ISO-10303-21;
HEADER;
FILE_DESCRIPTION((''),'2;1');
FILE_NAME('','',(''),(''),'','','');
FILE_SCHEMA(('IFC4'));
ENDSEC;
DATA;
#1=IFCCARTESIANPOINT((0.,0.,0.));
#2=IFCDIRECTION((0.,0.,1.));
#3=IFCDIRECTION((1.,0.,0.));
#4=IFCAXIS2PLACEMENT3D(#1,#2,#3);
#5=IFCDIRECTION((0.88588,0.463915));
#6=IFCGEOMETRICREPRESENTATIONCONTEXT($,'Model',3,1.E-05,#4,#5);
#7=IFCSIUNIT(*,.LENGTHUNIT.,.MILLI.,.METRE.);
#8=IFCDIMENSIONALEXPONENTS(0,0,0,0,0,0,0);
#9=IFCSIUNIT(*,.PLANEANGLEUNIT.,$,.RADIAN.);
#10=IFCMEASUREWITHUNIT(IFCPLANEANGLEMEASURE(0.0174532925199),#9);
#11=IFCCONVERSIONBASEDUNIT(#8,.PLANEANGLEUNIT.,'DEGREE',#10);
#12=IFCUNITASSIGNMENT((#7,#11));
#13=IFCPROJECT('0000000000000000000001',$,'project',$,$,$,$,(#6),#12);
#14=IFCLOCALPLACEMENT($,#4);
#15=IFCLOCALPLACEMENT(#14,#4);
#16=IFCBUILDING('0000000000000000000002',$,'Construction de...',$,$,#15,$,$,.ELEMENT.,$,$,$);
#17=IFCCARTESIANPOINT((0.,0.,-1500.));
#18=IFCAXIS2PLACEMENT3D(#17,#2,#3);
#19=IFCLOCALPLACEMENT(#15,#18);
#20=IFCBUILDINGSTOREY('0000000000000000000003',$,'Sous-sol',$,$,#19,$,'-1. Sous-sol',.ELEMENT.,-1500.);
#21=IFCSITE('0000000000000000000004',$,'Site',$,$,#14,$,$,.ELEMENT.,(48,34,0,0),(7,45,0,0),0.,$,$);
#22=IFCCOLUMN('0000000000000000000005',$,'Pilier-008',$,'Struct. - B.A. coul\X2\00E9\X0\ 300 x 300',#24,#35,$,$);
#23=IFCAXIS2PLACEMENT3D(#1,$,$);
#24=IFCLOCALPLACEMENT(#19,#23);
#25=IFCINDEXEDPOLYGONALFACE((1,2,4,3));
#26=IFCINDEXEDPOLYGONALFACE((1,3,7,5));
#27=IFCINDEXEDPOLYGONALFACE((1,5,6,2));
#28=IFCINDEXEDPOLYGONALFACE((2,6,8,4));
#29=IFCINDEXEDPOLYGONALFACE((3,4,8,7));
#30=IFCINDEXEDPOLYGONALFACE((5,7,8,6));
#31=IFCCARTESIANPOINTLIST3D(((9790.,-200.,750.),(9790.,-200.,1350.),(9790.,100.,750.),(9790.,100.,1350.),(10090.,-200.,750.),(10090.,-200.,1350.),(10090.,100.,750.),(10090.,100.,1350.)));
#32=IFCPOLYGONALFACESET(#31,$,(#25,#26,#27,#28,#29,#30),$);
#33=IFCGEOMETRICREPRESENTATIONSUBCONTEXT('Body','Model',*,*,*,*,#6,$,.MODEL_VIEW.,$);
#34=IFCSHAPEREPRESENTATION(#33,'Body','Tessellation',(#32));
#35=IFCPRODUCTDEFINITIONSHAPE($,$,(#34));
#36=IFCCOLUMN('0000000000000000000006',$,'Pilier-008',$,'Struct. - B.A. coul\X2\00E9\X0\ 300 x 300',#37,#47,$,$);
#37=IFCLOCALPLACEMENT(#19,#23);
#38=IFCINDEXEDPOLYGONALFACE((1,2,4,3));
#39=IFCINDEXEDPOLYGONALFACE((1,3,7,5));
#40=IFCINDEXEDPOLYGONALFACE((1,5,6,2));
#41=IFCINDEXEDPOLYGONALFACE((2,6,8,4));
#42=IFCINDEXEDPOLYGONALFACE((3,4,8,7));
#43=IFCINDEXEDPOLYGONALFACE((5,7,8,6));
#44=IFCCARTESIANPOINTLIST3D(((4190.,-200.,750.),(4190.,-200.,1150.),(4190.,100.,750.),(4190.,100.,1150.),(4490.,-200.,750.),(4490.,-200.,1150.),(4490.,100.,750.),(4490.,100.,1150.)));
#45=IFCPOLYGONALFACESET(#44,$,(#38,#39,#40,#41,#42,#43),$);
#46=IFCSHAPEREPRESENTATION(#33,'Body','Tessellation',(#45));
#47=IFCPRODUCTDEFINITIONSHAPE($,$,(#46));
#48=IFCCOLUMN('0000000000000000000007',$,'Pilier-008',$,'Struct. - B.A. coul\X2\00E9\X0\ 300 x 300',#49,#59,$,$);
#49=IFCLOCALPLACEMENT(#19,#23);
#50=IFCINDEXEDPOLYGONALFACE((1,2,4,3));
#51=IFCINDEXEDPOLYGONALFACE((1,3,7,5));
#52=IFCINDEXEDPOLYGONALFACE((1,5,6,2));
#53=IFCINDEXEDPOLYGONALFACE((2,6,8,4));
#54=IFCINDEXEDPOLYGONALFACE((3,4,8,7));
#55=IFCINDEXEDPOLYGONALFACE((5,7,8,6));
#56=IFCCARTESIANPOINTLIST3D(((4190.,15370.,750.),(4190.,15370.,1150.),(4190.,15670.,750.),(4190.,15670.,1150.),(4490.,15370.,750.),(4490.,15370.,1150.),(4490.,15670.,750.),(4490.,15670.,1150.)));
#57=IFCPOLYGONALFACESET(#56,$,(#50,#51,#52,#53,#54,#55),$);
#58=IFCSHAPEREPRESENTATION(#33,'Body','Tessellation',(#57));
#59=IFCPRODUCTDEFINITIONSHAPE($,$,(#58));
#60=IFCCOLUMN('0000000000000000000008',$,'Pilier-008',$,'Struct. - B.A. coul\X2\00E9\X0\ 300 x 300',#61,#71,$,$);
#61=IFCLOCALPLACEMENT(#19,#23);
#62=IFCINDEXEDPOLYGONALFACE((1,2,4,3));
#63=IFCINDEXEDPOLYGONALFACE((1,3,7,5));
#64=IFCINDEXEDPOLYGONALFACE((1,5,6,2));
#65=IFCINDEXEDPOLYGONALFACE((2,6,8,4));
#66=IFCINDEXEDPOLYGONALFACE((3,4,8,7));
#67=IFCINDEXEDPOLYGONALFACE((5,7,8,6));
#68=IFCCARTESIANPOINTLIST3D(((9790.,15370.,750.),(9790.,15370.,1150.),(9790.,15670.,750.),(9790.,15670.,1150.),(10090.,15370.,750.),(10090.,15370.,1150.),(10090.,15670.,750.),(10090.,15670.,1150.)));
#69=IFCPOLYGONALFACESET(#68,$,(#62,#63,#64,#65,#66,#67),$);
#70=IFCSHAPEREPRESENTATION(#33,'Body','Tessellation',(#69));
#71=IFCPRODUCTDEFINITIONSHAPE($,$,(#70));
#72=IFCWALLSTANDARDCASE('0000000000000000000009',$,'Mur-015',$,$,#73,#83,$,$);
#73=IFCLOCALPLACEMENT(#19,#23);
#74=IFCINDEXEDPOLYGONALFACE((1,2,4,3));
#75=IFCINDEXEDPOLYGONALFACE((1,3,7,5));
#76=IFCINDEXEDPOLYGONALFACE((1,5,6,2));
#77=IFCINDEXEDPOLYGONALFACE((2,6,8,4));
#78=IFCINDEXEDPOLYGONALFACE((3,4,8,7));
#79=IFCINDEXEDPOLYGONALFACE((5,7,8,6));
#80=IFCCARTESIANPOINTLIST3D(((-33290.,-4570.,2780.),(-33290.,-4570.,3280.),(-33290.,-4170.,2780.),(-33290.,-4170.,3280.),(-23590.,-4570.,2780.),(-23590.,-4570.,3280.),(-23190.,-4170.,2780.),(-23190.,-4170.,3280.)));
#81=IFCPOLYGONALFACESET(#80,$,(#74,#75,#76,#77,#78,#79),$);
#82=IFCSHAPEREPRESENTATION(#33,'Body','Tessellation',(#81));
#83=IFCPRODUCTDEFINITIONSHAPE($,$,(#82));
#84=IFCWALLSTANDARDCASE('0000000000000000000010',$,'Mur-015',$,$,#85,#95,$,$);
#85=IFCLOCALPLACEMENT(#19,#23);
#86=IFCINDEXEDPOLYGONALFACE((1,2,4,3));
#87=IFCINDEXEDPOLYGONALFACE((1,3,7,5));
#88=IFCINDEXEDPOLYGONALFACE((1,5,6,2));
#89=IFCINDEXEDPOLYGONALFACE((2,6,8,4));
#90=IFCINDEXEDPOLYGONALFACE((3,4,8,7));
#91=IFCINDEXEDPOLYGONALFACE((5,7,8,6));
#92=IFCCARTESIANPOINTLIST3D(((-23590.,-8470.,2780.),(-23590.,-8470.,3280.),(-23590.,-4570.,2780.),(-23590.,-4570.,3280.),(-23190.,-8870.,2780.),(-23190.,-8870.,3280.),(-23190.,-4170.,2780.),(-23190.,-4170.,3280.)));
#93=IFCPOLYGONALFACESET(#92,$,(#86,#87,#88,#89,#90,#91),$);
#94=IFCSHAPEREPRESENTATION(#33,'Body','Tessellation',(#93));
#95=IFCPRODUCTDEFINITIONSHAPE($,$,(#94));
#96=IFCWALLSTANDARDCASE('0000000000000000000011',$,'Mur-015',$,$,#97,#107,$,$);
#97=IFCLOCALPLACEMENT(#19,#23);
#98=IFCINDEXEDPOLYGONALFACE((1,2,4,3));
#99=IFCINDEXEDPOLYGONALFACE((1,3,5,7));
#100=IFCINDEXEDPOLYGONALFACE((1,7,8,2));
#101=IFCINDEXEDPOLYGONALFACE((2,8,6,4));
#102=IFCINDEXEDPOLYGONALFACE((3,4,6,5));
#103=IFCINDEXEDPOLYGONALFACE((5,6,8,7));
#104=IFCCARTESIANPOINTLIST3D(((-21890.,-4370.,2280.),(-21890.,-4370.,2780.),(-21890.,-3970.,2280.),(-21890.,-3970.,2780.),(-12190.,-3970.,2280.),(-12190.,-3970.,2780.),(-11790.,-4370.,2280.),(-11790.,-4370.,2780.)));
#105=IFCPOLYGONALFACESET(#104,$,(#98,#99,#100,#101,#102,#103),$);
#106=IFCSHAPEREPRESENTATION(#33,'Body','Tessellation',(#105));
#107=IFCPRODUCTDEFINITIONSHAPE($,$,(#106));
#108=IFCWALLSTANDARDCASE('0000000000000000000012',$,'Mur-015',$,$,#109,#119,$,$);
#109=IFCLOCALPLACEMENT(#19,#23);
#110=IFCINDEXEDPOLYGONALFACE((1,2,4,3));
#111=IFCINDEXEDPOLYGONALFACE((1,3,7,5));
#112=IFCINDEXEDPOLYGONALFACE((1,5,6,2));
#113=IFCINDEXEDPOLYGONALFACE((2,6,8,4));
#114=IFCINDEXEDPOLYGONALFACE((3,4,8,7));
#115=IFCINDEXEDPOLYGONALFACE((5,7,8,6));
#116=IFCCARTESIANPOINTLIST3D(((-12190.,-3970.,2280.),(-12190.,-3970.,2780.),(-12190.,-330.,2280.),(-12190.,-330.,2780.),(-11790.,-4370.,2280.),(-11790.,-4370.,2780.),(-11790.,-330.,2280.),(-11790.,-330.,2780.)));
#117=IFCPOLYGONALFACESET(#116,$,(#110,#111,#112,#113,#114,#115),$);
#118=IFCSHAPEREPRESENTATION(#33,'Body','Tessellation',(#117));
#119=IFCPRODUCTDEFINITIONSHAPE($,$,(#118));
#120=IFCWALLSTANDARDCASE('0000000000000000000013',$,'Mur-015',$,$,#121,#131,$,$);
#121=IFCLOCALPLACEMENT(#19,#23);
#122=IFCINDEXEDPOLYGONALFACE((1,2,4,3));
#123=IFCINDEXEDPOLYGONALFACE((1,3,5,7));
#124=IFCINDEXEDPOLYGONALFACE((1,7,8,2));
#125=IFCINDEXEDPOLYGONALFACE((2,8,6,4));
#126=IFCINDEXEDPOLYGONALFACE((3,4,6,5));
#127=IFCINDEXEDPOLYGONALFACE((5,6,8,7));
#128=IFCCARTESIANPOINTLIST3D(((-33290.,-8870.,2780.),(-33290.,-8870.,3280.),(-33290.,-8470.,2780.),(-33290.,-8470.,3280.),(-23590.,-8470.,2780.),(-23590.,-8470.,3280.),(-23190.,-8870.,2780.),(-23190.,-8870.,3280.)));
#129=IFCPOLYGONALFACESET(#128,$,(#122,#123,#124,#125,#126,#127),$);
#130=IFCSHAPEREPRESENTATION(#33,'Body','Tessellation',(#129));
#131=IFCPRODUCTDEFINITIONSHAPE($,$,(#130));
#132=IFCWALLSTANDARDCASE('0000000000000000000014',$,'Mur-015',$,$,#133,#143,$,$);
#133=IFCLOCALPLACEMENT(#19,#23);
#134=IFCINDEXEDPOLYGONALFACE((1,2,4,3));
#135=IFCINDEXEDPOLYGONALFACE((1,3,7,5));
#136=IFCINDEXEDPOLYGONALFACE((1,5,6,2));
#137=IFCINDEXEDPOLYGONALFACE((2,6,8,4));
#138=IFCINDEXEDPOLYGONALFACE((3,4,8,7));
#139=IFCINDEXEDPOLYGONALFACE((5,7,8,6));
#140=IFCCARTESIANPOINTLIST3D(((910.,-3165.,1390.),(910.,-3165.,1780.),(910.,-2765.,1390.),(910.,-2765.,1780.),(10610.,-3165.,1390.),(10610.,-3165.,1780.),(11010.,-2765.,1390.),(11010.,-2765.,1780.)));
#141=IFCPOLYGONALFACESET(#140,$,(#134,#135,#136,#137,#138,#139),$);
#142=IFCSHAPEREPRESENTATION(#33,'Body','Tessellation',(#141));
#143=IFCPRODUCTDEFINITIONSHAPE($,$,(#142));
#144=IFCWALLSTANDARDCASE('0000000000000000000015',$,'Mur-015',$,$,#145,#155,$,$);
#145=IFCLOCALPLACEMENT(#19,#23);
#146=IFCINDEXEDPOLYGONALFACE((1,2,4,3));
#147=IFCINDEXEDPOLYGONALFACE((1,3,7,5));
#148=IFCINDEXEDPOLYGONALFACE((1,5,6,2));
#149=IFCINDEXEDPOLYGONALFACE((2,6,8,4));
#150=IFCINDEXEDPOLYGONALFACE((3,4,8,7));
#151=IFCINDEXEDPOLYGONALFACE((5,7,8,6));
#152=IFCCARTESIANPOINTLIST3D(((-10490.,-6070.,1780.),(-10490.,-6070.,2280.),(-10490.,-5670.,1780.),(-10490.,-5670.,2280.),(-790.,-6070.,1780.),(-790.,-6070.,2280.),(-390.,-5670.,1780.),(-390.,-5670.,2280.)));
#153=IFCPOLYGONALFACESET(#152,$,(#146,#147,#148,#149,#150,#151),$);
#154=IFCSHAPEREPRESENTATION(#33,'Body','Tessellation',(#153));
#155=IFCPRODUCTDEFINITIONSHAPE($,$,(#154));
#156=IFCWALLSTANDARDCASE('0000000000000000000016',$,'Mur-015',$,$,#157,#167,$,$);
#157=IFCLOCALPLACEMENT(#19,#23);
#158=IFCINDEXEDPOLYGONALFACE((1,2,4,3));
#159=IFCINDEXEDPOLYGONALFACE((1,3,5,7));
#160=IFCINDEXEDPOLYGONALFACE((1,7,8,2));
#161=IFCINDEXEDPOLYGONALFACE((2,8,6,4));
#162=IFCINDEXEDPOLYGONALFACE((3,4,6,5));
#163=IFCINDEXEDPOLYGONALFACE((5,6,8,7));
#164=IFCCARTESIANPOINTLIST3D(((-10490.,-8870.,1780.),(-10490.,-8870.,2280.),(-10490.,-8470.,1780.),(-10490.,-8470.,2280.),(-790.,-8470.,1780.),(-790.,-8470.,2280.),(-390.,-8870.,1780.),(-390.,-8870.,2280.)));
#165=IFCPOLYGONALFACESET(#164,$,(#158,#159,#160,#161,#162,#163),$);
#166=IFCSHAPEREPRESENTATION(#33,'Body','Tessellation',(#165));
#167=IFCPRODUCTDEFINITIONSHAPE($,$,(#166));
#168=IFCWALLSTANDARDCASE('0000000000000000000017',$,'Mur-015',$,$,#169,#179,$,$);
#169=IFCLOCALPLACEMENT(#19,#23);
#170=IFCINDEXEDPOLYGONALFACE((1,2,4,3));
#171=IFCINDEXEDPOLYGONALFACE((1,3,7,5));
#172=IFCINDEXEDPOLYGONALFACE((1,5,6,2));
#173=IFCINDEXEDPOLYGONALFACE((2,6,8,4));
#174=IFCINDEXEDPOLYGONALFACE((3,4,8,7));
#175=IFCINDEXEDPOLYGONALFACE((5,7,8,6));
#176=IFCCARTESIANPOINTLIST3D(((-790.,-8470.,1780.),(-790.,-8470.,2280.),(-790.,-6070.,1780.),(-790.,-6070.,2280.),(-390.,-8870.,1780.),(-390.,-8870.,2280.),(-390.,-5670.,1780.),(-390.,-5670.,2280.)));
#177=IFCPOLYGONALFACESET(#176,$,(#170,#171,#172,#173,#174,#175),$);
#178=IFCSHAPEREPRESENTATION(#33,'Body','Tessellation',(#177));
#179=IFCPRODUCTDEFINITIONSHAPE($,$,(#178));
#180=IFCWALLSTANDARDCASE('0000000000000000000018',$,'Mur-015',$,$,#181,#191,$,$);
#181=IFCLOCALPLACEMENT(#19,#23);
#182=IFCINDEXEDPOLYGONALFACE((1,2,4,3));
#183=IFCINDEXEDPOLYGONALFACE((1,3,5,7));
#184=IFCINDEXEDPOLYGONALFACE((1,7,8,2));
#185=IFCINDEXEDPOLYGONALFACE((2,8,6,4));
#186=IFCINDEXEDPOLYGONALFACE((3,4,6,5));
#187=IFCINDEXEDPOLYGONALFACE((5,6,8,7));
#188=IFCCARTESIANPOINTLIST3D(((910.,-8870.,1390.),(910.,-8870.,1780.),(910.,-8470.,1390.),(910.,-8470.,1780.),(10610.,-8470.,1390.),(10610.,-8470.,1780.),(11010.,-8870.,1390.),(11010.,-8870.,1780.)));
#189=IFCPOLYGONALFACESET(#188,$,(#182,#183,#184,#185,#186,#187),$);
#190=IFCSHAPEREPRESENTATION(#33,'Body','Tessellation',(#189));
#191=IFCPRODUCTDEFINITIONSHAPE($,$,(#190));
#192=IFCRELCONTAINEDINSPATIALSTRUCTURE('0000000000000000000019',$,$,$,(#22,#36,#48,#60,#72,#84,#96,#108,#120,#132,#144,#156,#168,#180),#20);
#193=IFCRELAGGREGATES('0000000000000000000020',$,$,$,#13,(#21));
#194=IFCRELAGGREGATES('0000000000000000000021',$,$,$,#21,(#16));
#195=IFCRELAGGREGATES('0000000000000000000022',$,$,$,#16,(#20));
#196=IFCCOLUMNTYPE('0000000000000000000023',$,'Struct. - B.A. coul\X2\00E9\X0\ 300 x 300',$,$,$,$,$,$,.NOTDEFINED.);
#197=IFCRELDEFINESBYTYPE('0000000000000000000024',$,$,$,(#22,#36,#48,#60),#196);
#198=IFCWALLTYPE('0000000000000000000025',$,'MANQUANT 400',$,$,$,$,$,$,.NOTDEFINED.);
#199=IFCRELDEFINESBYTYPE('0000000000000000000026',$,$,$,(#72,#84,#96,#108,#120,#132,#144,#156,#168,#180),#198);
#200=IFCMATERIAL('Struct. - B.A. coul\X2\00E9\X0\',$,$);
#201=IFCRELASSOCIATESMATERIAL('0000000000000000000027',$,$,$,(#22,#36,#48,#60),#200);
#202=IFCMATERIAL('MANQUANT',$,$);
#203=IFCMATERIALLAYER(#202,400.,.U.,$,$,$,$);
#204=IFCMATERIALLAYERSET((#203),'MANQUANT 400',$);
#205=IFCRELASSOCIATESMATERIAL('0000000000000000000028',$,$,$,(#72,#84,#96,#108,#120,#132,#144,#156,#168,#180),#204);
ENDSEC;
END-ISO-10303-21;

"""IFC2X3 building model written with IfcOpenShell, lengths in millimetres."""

from ifc_helpers import new_model, entity, si_unit, converted_unit, direction, frame, origin_with_axes, origin_2d_with_axis, place, context, subcontext, project, spatial, polyline, rectangle, outline, extrude, material, layer, layer_set, layer_usage, type_object, element, save


model = new_model("IFC2X3")

# Units and contexts
model_context = context("Model", 3, precision=1e-05, world=origin_with_axes(), true_north=direction((0.88588, 0.463915)))
body_context = subcontext(model_context, "Body", "Model", "MODEL_VIEW")
ifc_project = project(units=[si_unit("LENGTHUNIT", "METRE", prefix="MILLI"), converted_unit("PLANEANGLEUNIT", "DEGREE", entity("IfcPlaneAngleMeasure", 0.0174532925199), si_unit("PLANEANGLEUNIT", "RADIAN"), dimensions=[0, 0, 0, 0, 0, 0, 0])], contexts=[model_context])

# Site, building, storey
site_placement = place(None, origin_with_axes())
site = spatial("IfcSite", under=ifc_project, at=site_placement, Name="Site", CompositionType="ELEMENT", RefLatitude=(48, 34, 0, 0), RefLongitude=(7, 45, 0, 0), RefElevation=0.0)
building_placement = place(site_placement, origin_with_axes())
building = spatial("IfcBuilding", under=site, at=building_placement, Name="Construction de...", CompositionType="ELEMENT")
storey_placement = place(building_placement, frame((0.0, 0.0, -1500.0), z_axis=(0.0, 0.0, 1.0), x_axis=(1.0, 0.0, 0.0)))
storey = spatial("IfcBuildingStorey", under=building, at=storey_placement, Name="Sous-sol", LongName="-1. Sous-sol", CompositionType="ELEMENT", Elevation=-1500.0)

# Shared definitions
ifc_material_1 = material(Name="Struct. - B.A. coulé")

# Columns
column_type = type_object("IfcColumnType", Name="Struct. - B.A. coulé 300 x 300", PredefinedType="NOTDEFINED")
column_placement = place(storey_placement, frame((9940.0, -50.0, 750.0), z_axis=(0.0, 0.0, 1.0), x_axis=(1.0, 0.0, 0.0)))
element("IfcColumn", 1, at=column_placement, inside=storey, type_object=column_type, material=ifc_material_1, Name="Pilier-008", ObjectType="Struct. - B.A. coulé 300 x 300", context=body_context, shape_type="SweptSolid", body=[
    extrude(rectangle(XDim=300.0, YDim=300.0, at=origin_2d_with_axis()), origin_with_axes(), (0.0, 0.0, 1.0), 600.0),
])
for number, where, z_axis, x_axis, name in (
    (2, (4340.0, -50.0, 750.0), (0.0, 0.0, 1.0), (1.0, 0.0, 0.0), "Pilier-008"),
    (3, (4340.0, 15520.0, 750.0), (0.0, 0.0, 1.0), (1.0, 0.0, 0.0), "Pilier-008"),
    (4, (9940.0, 15520.0, 750.0), (0.0, 0.0, 1.0), (1.0, 0.0, 0.0), "Pilier-008"),
):
    element("IfcColumn", number, at=place(storey_placement, frame(where, z_axis=z_axis, x_axis=x_axis)), inside=storey, type_object=column_type, material=ifc_material_1, Name=name, ObjectType="Struct. - B.A. coulé 300 x 300", context=body_context, shape_type="SweptSolid", body=[
        extrude(rectangle(XDim=300.0, YDim=300.0, at=origin_2d_with_axis()), origin_with_axes(), (0.0, 0.0, 1.0), 400.0),
    ])

# Walls
ifc_material_2 = material(Name="MANQUANT")
ifc_layer_1 = layer(ifc_material_2, 400.0, ventilated="UNKNOWN")
ifc_layer_set_1 = layer_set([ifc_layer_1], Name="MANQUANT 400")
ifc_layer_usage_1 = layer_usage(ifc_layer_set_1, "AXIS2", "NEGATIVE", 200.0)
wall_type_1 = type_object("IfcWallType", Name="MANQUANT 400", PredefinedType="NOTDEFINED")
wall_1_placement = place(storey_placement, frame((-33290.0, -4370.0, 2780.0), z_axis=(0.0, 0.0, 1.0), x_axis=(1.0, 0.0, 0.0)))
element("IfcWallStandardCase", 5, at=wall_1_placement, inside=storey, type_object=wall_type_1, material=ifc_layer_usage_1, Name="Mur-015", context=body_context, shape_type="SweptSolid", body=[
    extrude(outline(polyline([(0.0, -200.0), (9700.0, -200.0), (10100.0, 200.0), (0.0, 200.0), (0.0, -200.0)])), origin_with_axes(), (0.0, 0.0, 1.0), 500.0),
])
ifc_layer_usage_2 = layer_usage(ifc_layer_set_1, "AXIS2", "POSITIVE", -200.0)
wall_2_placement = place(storey_placement, frame((-23390.0, -4370.0, 2780.0), z_axis=(0.0, 0.0, 1.0), x_axis=(0.0, -1.0, 0.0)))
element("IfcWallStandardCase", 6, at=wall_2_placement, inside=storey, type_object=wall_type_1, material=ifc_layer_usage_2, Name="Mur-015", context=body_context, shape_type="SweptSolid", body=[
    extrude(outline(polyline([(200.0, -200.0), (4100.0, -200.0), (4500.0, 200.0), (-200.0, 200.0), (200.0, -200.0)])), origin_with_axes(), (0.0, 0.0, 1.0), 500.0),
])
ifc_layer_usage_3 = layer_usage(ifc_layer_set_1, "AXIS2", "NEGATIVE", 200.0)
wall_3_placement = place(storey_placement, frame((-21890.0, -4170.0, 2280.0), z_axis=(0.0, 0.0, 1.0), x_axis=(1.0, 0.0, 0.0)))
element("IfcWallStandardCase", 7, at=wall_3_placement, inside=storey, type_object=wall_type_1, material=ifc_layer_usage_3, Name="Mur-015", context=body_context, shape_type="SweptSolid", body=[
    extrude(outline(polyline([(0.0, -200.0), (10100.0, -200.0), (9700.0, 200.0), (0.0, 200.0), (0.0, -200.0)])), origin_with_axes(), (0.0, 0.0, 1.0), 500.0),
])
ifc_layer_usage_4 = layer_usage(ifc_layer_set_1, "AXIS2", "POSITIVE", -200.0)
wall_4_placement = place(storey_placement, frame((-11990.0, -330.0, 2280.0), z_axis=(0.0, 0.0, 1.0), x_axis=(0.0, -1.0, 0.0)))
element("IfcWallStandardCase", 8, at=wall_4_placement, inside=storey, type_object=wall_type_1, material=ifc_layer_usage_4, Name="Mur-015", context=body_context, shape_type="SweptSolid", body=[
    extrude(outline(polyline([(0.0, -200.0), (3640.0, -200.0), (4040.0, 200.0), (0.0, 200.0), (0.0, -200.0)])), origin_with_axes(), (0.0, 0.0, 1.0), 500.0),
])
ifc_layer_usage_5 = layer_usage(ifc_layer_set_1, "AXIS2", "NEGATIVE", 200.0)
wall_5_placement = place(storey_placement, frame((-33290.0, -8670.0, 2780.0), z_axis=(0.0, 0.0, 1.0), x_axis=(1.0, 0.0, 0.0)))
element("IfcWallStandardCase", 9, at=wall_5_placement, inside=storey, type_object=wall_type_1, material=ifc_layer_usage_5, Name="Mur-015", context=body_context, shape_type="SweptSolid", body=[
    extrude(outline(polyline([(0.0, -200.0), (10100.0, -200.0), (9700.0, 200.0), (0.0, 200.0), (0.0, -200.0)])), origin_with_axes(), (0.0, 0.0, 1.0), 500.0),
])
ifc_layer_usage_6 = layer_usage(ifc_layer_set_1, "AXIS2", "NEGATIVE", 200.0)
wall_6_placement = place(storey_placement, frame((910.0, -2965.0, 1390.0), z_axis=(0.0, 0.0, 1.0), x_axis=(1.0, 0.0, 0.0)))
element("IfcWallStandardCase", 10, at=wall_6_placement, inside=storey, type_object=wall_type_1, material=ifc_layer_usage_6, Name="Mur-015", context=body_context, shape_type="SweptSolid", body=[
    extrude(outline(polyline([(0.0, -200.0), (9700.0, -200.0), (10100.0, 200.0), (0.0, 200.0), (0.0, -200.0)])), origin_with_axes(), (0.0, 0.0, 1.0), 390.0),
])
ifc_layer_usage_7 = layer_usage(ifc_layer_set_1, "AXIS2", "NEGATIVE", 200.0)
wall_7_placement = place(storey_placement, frame((-10490.0, -5870.0, 1780.0), z_axis=(0.0, 0.0, 1.0), x_axis=(1.0, 0.0, 0.0)))
element("IfcWallStandardCase", 11, at=wall_7_placement, inside=storey, type_object=wall_type_1, material=ifc_layer_usage_7, Name="Mur-015", context=body_context, shape_type="SweptSolid", body=[
    extrude(outline(polyline([(0.0, -200.0), (9700.0, -200.0), (10100.0, 200.0), (0.0, 200.0), (0.0, -200.0)])), origin_with_axes(), (0.0, 0.0, 1.0), 500.0),
])
ifc_layer_usage_8 = layer_usage(ifc_layer_set_1, "AXIS2", "NEGATIVE", 200.0)
wall_8_placement = place(storey_placement, frame((-10490.0, -8670.0, 1780.0), z_axis=(0.0, 0.0, 1.0), x_axis=(1.0, 0.0, 0.0)))
element("IfcWallStandardCase", 12, at=wall_8_placement, inside=storey, type_object=wall_type_1, material=ifc_layer_usage_8, Name="Mur-015", context=body_context, shape_type="SweptSolid", body=[
    extrude(outline(polyline([(0.0, -200.0), (10100.0, -200.0), (9700.0, 200.0), (0.0, 200.0), (0.0, -200.0)])), origin_with_axes(), (0.0, 0.0, 1.0), 500.0),
])
ifc_layer_usage_9 = layer_usage(ifc_layer_set_1, "AXIS2", "POSITIVE", -200.0)
wall_9_placement = place(storey_placement, frame((-590.0, -5870.0, 1780.0), z_axis=(0.0, 0.0, 1.0), x_axis=(0.0, -1.0, 0.0)))
element("IfcWallStandardCase", 13, at=wall_9_placement, inside=storey, type_object=wall_type_1, material=ifc_layer_usage_9, Name="Mur-015", context=body_context, shape_type="SweptSolid", body=[
    extrude(outline(polyline([(200.0, -200.0), (2600.0, -200.0), (3000.0, 200.0), (-200.0, 200.0), (200.0, -200.0)])), origin_with_axes(), (0.0, 0.0, 1.0), 500.0),
])
ifc_layer_usage_10 = layer_usage(ifc_layer_set_1, "AXIS2", "NEGATIVE", 200.0)
wall_10_placement = place(storey_placement, frame((910.0, -8670.0, 1390.0), z_axis=(0.0, 0.0, 1.0), x_axis=(1.0, 0.0, 0.0)))
element("IfcWallStandardCase", 14, at=wall_10_placement, inside=storey, type_object=wall_type_1, material=ifc_layer_usage_10, Name="Mur-015", context=body_context, shape_type="SweptSolid", body=[
    extrude(outline(polyline([(0.0, -200.0), (10100.0, -200.0), (9700.0, 200.0), (0.0, 200.0), (0.0, -200.0)])), origin_with_axes(), (0.0, 0.0, 1.0), 390.0),
])

save(model, "model.ifc")
